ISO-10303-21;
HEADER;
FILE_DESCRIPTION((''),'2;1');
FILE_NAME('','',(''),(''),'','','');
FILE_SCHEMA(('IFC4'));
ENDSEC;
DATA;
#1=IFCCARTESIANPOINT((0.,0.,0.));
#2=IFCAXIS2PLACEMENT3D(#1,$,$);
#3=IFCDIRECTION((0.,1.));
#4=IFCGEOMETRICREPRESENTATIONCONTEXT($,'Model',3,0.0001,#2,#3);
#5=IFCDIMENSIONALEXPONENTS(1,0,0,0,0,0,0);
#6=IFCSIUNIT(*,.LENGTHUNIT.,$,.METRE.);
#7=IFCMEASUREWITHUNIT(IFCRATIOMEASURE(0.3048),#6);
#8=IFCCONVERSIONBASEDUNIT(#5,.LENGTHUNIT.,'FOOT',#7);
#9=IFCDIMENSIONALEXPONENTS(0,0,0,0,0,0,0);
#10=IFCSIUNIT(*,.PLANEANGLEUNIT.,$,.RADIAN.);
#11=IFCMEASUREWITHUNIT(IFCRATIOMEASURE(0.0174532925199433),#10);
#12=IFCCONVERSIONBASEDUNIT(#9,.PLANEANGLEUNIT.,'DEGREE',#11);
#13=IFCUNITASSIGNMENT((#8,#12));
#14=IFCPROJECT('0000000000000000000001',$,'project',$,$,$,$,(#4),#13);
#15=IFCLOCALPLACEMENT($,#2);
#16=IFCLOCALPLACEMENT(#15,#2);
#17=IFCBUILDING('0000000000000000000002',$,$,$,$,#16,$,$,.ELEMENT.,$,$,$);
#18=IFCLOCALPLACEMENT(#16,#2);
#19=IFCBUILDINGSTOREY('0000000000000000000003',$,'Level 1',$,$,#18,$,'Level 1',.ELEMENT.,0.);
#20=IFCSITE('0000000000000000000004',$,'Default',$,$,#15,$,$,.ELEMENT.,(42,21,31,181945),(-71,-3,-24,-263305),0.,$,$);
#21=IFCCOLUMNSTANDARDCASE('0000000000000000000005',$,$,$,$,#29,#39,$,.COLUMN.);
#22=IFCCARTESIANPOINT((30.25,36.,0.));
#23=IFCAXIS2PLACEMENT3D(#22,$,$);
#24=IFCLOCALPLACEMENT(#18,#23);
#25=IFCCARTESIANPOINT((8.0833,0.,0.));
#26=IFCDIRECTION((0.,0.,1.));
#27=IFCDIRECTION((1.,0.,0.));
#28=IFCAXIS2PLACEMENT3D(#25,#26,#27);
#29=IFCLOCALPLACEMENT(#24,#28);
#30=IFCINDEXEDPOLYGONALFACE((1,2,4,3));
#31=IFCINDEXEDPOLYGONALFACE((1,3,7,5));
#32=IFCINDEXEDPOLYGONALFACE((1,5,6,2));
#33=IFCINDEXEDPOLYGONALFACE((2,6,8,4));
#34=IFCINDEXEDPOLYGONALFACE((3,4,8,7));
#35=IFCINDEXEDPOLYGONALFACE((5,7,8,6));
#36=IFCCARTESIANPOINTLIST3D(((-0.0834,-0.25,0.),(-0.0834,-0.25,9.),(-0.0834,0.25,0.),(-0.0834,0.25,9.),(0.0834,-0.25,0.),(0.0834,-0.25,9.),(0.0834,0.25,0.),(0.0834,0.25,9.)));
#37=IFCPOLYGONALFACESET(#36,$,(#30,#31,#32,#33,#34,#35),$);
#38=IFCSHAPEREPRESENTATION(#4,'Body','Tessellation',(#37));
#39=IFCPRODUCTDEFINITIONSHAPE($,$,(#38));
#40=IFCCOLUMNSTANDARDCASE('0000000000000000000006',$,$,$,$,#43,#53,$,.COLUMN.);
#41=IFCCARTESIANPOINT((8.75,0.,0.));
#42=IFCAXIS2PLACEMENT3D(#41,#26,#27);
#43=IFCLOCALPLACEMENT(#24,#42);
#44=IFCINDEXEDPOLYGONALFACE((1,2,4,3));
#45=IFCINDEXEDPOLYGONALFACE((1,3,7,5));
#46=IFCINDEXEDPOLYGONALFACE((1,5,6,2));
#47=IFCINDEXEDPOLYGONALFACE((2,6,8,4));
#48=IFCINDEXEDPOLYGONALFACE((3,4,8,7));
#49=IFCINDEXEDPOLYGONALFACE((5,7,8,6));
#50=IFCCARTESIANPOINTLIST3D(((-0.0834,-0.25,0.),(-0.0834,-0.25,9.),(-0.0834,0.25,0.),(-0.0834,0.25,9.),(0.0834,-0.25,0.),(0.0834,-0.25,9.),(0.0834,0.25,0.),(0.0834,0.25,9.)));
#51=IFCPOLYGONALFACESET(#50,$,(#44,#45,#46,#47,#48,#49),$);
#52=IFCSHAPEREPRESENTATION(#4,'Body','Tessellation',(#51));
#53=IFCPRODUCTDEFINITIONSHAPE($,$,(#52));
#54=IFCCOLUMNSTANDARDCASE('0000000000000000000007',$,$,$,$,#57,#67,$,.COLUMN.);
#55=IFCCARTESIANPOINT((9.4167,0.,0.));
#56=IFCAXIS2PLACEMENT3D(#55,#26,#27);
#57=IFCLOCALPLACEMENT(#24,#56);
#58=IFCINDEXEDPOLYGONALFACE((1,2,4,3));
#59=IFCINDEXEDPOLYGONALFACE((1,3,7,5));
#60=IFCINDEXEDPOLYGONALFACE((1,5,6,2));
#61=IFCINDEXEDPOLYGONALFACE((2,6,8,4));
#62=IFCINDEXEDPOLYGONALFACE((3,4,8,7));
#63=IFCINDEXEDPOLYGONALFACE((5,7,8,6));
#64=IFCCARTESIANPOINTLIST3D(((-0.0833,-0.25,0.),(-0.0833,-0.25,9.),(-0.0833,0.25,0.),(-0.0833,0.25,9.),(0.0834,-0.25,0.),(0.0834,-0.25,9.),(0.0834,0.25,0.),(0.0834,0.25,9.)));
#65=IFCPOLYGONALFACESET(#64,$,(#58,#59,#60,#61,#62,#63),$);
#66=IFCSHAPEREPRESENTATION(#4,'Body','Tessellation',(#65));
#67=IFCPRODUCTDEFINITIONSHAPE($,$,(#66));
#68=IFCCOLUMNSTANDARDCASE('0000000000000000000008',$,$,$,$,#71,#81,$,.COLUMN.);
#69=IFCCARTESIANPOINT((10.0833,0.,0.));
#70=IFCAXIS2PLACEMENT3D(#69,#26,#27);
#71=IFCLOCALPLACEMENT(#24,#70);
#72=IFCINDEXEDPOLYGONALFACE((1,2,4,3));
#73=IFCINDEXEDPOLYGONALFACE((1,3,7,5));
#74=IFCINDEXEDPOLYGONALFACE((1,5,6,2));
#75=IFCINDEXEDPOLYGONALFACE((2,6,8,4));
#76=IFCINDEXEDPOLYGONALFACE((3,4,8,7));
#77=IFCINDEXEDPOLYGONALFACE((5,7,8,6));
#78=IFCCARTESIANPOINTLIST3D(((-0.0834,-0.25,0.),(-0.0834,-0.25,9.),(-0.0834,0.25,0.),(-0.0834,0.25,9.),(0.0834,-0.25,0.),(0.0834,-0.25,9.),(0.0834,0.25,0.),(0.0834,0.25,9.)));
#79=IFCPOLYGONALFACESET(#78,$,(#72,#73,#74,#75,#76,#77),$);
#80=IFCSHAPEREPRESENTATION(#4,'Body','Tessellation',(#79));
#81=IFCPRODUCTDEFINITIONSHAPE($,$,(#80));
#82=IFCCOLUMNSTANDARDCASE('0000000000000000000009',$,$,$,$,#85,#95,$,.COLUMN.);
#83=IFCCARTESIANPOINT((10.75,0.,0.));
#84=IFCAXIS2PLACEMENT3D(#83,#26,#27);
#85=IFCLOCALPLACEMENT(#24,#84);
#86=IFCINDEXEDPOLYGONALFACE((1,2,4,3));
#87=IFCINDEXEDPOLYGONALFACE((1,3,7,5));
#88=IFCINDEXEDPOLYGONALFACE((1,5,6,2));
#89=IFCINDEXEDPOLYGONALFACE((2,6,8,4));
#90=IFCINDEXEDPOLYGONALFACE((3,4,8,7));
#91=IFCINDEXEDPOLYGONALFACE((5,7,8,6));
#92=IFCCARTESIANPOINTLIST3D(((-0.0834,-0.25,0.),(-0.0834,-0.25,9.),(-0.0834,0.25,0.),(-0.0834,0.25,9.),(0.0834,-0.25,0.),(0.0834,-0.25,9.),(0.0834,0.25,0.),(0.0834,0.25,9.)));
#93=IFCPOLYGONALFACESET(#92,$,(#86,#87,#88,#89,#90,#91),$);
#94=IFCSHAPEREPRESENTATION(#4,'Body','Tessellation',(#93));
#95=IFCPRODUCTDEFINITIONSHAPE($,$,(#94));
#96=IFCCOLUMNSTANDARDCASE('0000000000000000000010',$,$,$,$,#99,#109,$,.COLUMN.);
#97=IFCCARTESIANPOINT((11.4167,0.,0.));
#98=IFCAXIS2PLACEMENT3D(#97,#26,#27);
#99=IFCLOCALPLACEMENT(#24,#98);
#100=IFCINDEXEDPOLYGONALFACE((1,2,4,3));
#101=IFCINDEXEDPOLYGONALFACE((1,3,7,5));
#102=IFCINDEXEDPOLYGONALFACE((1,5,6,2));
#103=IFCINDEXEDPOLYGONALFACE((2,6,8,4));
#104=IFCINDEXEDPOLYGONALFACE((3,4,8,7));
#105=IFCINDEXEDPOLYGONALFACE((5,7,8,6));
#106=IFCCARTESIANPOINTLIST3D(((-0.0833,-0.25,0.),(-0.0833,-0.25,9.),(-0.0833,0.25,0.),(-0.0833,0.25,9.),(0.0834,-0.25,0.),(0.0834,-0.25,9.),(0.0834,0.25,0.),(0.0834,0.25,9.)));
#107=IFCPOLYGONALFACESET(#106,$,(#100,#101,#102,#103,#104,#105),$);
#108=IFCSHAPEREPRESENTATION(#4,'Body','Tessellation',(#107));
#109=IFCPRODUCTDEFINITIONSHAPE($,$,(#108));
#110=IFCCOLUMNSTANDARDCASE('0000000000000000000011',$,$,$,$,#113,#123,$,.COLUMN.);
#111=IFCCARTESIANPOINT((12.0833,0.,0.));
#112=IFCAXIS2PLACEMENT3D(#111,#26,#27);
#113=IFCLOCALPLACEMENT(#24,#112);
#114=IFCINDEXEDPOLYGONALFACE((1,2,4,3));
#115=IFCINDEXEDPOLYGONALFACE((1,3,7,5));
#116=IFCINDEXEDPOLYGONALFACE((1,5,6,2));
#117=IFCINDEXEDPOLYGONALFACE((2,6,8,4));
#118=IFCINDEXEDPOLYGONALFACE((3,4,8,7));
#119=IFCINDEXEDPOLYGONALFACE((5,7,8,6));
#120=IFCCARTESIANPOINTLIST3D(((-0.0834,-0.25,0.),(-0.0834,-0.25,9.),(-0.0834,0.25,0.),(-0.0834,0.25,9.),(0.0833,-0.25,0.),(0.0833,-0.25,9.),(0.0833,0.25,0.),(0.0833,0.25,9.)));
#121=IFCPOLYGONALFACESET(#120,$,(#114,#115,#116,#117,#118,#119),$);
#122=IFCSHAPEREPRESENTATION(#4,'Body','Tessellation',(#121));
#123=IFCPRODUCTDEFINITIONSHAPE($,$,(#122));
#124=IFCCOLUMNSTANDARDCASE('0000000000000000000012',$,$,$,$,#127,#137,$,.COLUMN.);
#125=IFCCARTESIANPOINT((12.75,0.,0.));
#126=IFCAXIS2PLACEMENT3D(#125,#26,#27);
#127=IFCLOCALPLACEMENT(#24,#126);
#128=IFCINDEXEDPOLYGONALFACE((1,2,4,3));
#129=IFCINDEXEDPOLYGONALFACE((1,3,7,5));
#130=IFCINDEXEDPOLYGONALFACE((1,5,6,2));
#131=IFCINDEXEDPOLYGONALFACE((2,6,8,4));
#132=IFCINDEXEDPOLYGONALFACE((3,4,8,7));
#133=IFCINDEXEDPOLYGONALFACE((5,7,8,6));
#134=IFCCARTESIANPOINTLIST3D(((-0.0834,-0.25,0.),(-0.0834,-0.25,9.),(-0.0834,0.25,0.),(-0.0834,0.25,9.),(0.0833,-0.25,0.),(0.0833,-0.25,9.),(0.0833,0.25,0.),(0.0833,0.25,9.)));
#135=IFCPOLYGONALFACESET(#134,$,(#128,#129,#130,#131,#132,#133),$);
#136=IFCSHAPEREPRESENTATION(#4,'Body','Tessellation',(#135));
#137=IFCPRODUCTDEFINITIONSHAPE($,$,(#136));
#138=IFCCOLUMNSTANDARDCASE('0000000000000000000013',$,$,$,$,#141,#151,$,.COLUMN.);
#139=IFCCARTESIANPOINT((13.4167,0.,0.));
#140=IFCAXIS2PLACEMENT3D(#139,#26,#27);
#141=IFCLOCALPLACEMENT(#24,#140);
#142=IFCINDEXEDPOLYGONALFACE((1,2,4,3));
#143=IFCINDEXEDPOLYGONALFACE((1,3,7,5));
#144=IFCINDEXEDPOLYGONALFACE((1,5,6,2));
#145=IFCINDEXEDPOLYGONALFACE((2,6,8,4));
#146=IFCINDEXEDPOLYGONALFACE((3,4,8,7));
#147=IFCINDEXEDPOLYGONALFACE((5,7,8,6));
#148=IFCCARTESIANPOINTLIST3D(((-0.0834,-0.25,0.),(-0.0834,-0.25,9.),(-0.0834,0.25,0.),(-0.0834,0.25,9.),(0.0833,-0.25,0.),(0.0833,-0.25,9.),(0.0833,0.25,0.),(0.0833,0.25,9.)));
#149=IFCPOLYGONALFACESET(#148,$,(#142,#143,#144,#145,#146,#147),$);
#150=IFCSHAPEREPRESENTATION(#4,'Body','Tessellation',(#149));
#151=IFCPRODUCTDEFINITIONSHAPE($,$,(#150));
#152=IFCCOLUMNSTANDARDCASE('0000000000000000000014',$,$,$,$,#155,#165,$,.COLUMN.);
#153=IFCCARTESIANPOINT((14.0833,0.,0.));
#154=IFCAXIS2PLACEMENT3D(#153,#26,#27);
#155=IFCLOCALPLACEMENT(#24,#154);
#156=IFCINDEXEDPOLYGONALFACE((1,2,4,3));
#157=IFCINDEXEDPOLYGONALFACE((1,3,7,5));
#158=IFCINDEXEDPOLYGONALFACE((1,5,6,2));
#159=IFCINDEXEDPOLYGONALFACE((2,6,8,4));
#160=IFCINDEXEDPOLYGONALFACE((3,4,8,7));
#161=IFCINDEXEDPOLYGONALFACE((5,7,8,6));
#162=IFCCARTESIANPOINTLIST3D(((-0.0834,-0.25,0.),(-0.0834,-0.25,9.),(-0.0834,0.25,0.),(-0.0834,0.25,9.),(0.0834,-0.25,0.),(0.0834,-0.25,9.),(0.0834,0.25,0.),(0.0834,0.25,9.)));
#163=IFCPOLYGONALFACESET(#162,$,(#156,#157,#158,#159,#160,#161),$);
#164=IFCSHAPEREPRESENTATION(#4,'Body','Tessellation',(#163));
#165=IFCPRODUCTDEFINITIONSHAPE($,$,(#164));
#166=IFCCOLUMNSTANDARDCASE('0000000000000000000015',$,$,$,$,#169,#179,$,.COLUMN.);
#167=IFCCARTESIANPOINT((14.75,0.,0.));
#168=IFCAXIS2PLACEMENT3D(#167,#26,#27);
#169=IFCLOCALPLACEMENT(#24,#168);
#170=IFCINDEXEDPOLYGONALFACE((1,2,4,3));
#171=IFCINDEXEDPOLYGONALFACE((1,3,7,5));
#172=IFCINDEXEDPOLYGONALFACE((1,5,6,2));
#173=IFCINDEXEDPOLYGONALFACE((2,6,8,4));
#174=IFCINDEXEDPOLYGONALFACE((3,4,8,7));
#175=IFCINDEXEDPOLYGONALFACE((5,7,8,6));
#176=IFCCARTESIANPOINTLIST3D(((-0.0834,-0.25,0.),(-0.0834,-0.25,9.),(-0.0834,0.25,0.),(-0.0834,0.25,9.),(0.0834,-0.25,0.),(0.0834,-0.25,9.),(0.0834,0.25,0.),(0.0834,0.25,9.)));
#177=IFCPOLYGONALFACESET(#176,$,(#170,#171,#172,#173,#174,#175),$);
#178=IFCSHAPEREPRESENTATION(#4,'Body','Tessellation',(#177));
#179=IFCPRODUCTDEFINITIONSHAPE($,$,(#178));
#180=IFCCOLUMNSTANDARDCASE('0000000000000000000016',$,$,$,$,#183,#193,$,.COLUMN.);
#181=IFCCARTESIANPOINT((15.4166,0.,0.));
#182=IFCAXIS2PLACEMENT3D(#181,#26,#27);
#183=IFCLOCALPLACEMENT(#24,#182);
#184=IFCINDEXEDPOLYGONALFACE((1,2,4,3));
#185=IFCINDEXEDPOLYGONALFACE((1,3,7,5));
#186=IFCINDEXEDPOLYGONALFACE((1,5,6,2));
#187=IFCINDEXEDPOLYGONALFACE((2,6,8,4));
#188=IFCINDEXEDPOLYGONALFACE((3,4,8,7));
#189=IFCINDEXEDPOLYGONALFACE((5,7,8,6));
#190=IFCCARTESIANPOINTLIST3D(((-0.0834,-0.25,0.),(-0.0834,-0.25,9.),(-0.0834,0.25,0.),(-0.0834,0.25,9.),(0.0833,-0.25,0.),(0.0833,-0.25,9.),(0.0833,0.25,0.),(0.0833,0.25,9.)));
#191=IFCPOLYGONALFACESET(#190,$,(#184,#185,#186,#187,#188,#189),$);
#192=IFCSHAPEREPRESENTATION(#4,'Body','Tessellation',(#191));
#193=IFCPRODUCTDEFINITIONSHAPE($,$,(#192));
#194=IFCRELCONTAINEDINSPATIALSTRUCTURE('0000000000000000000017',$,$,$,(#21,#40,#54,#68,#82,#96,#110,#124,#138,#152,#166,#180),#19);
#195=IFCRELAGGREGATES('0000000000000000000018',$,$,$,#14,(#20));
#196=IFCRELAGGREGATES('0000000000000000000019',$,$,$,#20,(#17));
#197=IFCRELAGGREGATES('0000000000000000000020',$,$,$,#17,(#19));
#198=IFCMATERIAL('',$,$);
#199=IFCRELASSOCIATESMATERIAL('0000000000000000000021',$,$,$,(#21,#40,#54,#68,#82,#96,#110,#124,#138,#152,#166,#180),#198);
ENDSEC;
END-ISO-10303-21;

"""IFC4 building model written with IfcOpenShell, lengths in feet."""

from ifc_helpers import new_model, entity, si_unit, converted_unit, direction, frame, origin, place, context, project, spatial, rectangle, extrude, material, element, save


model = new_model("IFC4")

# Units and contexts
model_context = context("Model", 3, precision=0.0001, world=origin(), true_north=direction((0.0, 1.0)))
ifc_project = project(units=[converted_unit("LENGTHUNIT", "FOOT", entity("IfcRatioMeasure", 0.3048), si_unit("LENGTHUNIT", "METRE"), dimensions=[1, 0, 0, 0, 0, 0, 0]), converted_unit("PLANEANGLEUNIT", "DEGREE", entity("IfcRatioMeasure", 0.0174532925199433), si_unit("PLANEANGLEUNIT", "RADIAN"), dimensions=[0, 0, 0, 0, 0, 0, 0])], contexts=[model_context])

# Site, building, storey
site_placement = place(None, origin())
site = spatial("IfcSite", under=ifc_project, at=site_placement, Name="Default", CompositionType="ELEMENT", RefLatitude=(42, 21, 31, 181945), RefLongitude=(-71, -3, -24, -263305), RefElevation=0.0)
building_placement = place(site_placement, origin())
building = spatial("IfcBuilding", under=site, at=building_placement, CompositionType="ELEMENT")
storey_placement = place(building_placement, origin())
storey = spatial("IfcBuildingStorey", under=building, at=storey_placement, Name="Level 1", LongName="Level 1", CompositionType="ELEMENT", Elevation=0.0)

# Columns
ifc_material_1 = material(Name="")
placement_1 = place(storey_placement, frame((30.25, 36.0, 0.0)))
for number, where, z_axis, x_axis in (
    (1, (8.0833, 0.0, 0.0), (0.0, 0.0, 1.0), (1.0, 0.0, 0.0)),
    (2, (8.75, 0.0, 0.0), (0.0, 0.0, 1.0), (1.0, 0.0, 0.0)),
    (3, (9.4167, 0.0, 0.0), (0.0, 0.0, 1.0), (1.0, 0.0, 0.0)),
    (4, (10.0833, 0.0, 0.0), (0.0, 0.0, 1.0), (1.0, 0.0, 0.0)),
    (5, (10.75, 0.0, 0.0), (0.0, 0.0, 1.0), (1.0, 0.0, 0.0)),
    (6, (11.4167, 0.0, 0.0), (0.0, 0.0, 1.0), (1.0, 0.0, 0.0)),
    (7, (12.0833, 0.0, 0.0), (0.0, 0.0, 1.0), (1.0, 0.0, 0.0)),
    (8, (12.75, 0.0, 0.0), (0.0, 0.0, 1.0), (1.0, 0.0, 0.0)),
    (9, (13.4167, 0.0, 0.0), (0.0, 0.0, 1.0), (1.0, 0.0, 0.0)),
    (10, (14.0833, 0.0, 0.0), (0.0, 0.0, 1.0), (1.0, 0.0, 0.0)),
    (11, (14.75, 0.0, 0.0), (0.0, 0.0, 1.0), (1.0, 0.0, 0.0)),
    (12, (15.4166, 0.0, 0.0), (0.0, 0.0, 1.0), (1.0, 0.0, 0.0)),
):
    element("IfcColumnStandardCase", number, at=place(placement_1, frame(where, z_axis=z_axis, x_axis=x_axis)), inside=storey, material=ifc_material_1, PredefinedType="COLUMN", context=model_context, shape_type="SweptSolid", body=[
        extrude(rectangle(XDim=0.1667, YDim=0.5), origin(), (0.0, 0.0, 1.0), 9.0),
    ])

save(model, "model.ifc")
